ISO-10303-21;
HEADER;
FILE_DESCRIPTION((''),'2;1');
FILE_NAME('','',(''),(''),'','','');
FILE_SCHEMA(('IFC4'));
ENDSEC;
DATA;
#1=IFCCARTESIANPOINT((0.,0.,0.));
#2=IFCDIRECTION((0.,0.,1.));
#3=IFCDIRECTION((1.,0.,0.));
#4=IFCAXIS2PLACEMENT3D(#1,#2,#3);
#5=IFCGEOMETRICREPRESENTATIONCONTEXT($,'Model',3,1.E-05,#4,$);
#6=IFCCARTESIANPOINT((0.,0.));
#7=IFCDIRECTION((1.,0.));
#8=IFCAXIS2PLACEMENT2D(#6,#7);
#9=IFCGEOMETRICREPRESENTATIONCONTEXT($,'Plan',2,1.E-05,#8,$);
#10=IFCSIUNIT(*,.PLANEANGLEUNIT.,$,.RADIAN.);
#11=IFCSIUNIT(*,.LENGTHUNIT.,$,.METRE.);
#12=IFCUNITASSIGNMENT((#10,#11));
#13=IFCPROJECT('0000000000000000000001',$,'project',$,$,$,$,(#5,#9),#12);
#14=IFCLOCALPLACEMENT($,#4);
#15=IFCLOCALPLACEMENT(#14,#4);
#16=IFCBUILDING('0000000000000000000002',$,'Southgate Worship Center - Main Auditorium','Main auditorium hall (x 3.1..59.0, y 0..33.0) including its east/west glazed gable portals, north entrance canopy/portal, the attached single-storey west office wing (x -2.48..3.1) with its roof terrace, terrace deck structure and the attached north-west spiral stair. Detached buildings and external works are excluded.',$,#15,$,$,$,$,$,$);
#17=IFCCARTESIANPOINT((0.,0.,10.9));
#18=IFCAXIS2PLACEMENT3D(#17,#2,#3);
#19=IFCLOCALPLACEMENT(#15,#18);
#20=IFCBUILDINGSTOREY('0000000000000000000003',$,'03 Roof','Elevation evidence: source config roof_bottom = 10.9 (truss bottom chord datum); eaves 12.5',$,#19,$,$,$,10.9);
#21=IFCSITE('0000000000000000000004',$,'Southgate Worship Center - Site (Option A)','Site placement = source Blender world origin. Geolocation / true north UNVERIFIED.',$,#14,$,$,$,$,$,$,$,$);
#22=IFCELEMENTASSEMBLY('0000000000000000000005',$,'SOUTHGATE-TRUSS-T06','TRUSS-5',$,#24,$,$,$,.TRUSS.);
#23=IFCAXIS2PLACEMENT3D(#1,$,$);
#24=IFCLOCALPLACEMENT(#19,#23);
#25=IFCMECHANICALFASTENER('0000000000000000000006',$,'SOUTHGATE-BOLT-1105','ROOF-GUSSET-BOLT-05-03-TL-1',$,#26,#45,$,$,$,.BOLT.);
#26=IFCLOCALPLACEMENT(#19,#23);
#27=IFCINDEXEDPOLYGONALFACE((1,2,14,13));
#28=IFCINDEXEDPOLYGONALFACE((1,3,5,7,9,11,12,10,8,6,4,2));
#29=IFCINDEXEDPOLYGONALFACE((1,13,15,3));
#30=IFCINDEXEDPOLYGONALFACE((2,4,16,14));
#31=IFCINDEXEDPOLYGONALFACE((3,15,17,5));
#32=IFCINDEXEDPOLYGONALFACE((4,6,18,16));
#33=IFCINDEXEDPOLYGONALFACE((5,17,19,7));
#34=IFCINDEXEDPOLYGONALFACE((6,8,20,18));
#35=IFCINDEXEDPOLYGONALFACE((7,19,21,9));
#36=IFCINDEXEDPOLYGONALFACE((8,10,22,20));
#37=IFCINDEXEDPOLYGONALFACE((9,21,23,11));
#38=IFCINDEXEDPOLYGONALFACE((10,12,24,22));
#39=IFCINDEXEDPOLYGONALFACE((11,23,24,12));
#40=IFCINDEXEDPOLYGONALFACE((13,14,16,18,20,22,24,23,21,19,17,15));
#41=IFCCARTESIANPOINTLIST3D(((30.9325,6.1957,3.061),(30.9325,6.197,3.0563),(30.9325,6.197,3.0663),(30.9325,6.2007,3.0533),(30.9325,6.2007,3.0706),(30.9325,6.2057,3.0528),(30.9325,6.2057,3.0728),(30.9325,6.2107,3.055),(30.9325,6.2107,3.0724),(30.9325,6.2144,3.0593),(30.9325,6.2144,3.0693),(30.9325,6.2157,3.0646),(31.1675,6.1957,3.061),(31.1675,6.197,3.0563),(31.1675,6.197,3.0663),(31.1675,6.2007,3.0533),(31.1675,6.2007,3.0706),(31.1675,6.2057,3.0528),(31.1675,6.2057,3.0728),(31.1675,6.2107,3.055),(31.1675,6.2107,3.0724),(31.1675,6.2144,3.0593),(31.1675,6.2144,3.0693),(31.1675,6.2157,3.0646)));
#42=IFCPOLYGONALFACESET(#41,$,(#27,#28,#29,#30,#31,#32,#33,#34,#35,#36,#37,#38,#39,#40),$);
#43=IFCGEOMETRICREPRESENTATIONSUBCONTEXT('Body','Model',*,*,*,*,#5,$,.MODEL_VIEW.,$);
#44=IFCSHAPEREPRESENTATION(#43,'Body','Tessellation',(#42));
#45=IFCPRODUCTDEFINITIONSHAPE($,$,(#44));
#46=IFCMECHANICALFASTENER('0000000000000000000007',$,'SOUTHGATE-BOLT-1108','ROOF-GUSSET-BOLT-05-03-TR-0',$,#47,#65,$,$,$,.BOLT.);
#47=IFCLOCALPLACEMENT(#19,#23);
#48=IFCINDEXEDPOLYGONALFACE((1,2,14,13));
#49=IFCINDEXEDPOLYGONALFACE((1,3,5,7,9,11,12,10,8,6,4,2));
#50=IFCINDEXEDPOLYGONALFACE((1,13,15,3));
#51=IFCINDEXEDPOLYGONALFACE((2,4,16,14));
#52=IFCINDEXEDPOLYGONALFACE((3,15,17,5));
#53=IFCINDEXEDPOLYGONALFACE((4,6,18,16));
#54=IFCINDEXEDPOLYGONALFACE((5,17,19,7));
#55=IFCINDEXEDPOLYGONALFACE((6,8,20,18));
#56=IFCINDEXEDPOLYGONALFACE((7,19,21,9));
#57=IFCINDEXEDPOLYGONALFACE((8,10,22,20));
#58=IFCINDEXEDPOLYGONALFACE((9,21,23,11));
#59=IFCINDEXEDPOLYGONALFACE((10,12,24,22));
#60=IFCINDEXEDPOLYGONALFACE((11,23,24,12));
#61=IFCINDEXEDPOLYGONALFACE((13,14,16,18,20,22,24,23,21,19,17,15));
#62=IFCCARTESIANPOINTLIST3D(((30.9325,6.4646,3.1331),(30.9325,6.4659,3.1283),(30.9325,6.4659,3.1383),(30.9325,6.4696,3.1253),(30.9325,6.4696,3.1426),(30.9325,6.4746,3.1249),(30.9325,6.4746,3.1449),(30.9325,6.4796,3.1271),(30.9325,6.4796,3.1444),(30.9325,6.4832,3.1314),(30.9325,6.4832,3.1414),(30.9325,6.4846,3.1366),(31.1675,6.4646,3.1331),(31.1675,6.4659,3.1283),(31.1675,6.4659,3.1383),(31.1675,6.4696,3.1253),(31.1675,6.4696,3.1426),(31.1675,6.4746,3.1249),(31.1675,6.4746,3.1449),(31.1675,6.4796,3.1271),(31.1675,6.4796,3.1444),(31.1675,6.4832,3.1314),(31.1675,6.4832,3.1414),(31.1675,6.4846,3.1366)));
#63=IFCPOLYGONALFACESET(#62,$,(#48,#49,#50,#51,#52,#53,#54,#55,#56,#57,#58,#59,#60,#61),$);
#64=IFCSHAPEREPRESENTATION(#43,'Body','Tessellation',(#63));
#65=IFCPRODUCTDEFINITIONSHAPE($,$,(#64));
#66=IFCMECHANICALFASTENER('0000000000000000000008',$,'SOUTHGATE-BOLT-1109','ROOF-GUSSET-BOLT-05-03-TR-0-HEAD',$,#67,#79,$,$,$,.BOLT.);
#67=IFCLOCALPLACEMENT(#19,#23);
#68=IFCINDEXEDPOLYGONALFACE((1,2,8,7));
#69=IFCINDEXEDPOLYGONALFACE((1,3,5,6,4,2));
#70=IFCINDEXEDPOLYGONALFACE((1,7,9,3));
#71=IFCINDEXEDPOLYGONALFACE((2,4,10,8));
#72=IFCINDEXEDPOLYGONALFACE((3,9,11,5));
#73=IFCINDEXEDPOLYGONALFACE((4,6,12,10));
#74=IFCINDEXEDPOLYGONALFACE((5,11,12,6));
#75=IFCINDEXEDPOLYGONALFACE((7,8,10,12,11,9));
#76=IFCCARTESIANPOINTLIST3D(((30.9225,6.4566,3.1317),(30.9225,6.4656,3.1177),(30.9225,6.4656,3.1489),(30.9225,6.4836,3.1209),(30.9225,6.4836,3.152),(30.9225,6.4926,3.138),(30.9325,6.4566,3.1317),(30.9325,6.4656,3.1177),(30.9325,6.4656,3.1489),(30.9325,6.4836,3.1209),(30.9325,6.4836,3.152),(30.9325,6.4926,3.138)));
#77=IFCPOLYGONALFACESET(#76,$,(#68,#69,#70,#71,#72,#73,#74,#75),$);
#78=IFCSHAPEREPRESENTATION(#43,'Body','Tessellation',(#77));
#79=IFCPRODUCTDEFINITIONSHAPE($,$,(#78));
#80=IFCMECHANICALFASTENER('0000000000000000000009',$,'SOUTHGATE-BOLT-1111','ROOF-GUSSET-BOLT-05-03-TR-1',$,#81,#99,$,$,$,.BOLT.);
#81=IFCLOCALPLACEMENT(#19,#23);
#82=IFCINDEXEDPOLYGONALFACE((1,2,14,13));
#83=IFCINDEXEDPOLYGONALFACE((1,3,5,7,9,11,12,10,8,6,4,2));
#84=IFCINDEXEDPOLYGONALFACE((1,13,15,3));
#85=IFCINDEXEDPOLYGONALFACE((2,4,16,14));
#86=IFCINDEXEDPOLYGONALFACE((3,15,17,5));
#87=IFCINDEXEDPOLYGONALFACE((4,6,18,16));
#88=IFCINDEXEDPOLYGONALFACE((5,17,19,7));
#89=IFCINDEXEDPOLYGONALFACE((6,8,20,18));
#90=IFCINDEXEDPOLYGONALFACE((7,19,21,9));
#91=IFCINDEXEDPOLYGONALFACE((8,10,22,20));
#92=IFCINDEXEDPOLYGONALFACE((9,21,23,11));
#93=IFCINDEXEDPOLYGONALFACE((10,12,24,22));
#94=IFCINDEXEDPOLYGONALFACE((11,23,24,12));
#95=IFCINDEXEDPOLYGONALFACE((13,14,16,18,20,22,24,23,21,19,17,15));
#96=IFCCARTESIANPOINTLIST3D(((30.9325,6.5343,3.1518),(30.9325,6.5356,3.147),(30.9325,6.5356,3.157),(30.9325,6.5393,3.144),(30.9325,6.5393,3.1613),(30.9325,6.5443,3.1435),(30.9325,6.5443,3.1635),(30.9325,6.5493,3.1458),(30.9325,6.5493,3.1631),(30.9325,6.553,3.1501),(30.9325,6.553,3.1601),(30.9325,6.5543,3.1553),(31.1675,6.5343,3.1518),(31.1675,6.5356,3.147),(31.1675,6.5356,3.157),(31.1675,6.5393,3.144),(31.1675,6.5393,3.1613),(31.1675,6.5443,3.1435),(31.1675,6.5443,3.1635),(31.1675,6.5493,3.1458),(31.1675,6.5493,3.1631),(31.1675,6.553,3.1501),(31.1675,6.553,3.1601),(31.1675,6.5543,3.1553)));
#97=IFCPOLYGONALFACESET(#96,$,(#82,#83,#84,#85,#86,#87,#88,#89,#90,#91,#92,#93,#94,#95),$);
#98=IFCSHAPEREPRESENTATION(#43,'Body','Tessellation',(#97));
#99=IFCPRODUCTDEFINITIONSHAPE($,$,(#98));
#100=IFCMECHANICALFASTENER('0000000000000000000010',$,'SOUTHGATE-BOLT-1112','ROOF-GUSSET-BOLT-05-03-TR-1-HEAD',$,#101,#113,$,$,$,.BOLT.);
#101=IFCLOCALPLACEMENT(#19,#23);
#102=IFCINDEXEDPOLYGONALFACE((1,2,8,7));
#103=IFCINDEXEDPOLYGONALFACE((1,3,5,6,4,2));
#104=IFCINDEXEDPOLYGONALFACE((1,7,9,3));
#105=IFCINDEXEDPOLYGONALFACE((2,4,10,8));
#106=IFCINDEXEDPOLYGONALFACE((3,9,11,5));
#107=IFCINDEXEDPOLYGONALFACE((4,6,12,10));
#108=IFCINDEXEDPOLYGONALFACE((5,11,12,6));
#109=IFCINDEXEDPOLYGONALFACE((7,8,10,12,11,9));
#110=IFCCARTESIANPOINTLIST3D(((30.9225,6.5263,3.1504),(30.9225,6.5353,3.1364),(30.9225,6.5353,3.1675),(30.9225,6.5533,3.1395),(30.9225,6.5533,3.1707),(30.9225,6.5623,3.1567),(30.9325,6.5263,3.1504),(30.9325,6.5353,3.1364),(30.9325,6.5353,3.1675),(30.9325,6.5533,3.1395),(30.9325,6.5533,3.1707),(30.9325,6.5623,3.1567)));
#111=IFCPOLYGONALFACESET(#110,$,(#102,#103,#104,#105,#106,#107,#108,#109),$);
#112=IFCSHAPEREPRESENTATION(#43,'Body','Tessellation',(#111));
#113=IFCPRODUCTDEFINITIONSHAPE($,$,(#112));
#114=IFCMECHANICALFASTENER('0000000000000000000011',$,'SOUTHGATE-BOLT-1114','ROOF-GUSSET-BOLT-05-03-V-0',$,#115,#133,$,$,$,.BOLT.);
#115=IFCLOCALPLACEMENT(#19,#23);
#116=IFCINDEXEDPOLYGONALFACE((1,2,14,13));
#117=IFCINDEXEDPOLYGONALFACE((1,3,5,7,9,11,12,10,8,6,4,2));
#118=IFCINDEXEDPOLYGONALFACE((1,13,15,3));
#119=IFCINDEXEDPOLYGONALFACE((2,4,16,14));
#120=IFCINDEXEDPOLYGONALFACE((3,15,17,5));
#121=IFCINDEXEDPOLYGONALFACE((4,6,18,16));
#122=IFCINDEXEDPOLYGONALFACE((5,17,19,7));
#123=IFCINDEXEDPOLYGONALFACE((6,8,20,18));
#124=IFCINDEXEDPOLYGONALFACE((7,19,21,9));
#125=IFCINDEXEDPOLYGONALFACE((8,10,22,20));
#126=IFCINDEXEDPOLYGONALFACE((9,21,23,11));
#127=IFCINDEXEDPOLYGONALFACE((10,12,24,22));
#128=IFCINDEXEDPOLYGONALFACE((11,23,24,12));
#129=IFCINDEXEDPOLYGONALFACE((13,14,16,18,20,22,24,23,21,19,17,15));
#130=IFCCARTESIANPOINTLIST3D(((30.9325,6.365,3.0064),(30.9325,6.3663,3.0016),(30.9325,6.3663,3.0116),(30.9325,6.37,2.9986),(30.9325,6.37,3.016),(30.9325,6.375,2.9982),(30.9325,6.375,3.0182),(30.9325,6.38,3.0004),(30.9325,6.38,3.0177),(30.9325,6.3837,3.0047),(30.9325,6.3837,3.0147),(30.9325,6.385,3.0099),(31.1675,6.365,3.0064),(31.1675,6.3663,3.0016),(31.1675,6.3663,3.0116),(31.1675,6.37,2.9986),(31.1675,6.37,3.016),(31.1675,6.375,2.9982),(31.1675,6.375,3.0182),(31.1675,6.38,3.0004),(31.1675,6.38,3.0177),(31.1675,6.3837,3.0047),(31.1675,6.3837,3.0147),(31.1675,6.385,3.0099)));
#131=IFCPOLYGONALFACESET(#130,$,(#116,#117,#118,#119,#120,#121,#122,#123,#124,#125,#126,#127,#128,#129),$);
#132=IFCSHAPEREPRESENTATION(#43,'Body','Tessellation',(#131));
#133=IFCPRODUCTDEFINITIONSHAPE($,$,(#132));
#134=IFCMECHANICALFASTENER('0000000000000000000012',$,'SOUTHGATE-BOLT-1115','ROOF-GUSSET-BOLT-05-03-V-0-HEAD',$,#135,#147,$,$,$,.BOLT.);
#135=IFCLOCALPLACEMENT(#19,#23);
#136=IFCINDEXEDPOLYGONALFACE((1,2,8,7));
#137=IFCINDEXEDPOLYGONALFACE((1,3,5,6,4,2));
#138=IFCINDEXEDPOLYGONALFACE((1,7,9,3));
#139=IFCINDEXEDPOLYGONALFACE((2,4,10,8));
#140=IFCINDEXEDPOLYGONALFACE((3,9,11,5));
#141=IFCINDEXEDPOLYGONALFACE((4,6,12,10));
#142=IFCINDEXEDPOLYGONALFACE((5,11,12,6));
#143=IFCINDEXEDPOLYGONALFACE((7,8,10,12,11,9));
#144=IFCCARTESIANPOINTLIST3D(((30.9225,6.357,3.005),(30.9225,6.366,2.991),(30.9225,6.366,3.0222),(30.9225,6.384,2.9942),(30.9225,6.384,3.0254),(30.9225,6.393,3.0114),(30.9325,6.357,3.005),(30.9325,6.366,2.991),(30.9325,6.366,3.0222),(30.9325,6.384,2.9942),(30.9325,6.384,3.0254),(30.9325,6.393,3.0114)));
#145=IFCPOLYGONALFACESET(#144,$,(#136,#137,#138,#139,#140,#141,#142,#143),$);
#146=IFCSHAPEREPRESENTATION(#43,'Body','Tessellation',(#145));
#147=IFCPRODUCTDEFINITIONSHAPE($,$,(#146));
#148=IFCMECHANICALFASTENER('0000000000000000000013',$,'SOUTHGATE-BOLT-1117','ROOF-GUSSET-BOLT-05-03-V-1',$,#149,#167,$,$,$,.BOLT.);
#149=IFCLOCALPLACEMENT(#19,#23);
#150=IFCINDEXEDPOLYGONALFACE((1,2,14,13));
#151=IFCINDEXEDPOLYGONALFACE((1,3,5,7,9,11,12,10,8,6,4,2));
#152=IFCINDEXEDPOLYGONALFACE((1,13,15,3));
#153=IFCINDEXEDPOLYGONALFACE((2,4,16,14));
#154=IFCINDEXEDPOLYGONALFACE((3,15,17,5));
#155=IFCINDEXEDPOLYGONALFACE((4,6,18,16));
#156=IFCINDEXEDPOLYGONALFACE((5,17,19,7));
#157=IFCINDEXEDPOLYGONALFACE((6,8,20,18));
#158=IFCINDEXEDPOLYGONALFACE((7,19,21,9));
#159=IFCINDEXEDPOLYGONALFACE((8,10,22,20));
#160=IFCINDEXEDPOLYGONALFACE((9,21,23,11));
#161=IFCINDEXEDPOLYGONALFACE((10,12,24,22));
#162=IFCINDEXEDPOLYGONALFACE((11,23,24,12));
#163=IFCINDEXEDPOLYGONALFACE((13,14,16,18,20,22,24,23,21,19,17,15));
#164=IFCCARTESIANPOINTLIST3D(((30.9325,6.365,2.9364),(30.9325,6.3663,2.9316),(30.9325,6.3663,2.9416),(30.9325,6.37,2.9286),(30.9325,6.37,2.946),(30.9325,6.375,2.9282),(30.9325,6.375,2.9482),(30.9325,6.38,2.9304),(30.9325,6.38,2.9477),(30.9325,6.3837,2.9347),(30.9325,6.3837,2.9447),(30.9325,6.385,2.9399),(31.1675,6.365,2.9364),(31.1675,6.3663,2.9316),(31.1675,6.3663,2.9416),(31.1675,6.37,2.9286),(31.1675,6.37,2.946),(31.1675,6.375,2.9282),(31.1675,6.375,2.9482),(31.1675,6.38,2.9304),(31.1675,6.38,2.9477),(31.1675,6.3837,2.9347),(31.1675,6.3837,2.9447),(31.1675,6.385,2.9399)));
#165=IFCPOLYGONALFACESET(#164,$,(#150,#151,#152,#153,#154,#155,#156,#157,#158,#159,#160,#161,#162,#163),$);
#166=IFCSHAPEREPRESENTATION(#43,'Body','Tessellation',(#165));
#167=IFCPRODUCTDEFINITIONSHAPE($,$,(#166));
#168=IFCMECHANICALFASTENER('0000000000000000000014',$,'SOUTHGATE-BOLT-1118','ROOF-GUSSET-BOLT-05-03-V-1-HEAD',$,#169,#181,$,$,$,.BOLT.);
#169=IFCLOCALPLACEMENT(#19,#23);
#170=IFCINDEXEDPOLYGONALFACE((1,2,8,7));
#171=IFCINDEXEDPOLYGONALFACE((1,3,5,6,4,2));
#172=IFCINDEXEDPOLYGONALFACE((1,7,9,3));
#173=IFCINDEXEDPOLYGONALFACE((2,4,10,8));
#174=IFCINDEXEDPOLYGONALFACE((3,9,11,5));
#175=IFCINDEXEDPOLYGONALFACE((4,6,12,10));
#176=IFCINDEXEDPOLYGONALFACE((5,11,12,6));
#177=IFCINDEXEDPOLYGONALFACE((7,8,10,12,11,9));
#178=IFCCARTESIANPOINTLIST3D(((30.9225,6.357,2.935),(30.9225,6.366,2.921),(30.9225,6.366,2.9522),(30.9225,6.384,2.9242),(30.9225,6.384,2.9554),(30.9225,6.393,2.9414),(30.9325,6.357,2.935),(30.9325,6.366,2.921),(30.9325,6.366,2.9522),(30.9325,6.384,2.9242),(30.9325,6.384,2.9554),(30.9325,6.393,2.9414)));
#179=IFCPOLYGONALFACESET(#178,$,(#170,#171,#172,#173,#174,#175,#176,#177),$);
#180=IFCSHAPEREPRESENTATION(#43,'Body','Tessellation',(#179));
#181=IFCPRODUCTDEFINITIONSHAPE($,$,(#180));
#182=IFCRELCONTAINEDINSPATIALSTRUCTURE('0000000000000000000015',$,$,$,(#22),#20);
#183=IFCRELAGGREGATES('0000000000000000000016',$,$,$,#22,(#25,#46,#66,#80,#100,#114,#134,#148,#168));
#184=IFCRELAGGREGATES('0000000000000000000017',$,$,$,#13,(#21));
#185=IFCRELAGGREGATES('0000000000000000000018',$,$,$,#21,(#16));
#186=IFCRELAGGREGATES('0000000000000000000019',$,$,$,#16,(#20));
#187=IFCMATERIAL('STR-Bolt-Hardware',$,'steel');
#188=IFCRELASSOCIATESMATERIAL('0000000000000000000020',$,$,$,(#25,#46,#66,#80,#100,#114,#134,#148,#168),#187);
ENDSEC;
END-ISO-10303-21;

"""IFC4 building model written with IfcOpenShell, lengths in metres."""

from ifc_helpers import new_model, si_unit, frame, origin_with_axes, origin_2d_with_axis, place, context, subcontext, project, spatial, indexed_curve, outline, extrude, material, element, aggregate, save


model = new_model("IFC4")

# Units and contexts
model_context = context("Model", 3, precision=1e-05, world=origin_with_axes())
plan_context = context("Plan", 2, precision=1e-05, world=origin_2d_with_axis())
body_context = subcontext(model_context, "Body", "Model", "MODEL_VIEW")
ifc_project = project(units=[si_unit("PLANEANGLEUNIT", "RADIAN"), si_unit("LENGTHUNIT", "METRE")], contexts=[model_context, plan_context])

# Site, building, storey
site_placement = place(None, origin_with_axes())
site = spatial("IfcSite", under=ifc_project, at=site_placement, Name="Southgate Worship Center - Site (Option A)", Description="Site placement = source Blender world origin. Geolocation / true north UNVERIFIED.")
building_placement = place(site_placement, origin_with_axes())
building = spatial("IfcBuilding", under=site, at=building_placement, Name="Southgate Worship Center - Main Auditorium", Description="Main auditorium hall (x 3.1..59.0, y 0..33.0) including its east/west glazed gable portals, north entrance canopy/portal, the attached single-storey west office wing (x -2.48..3.1) with its roof terrace, terrace deck structure and the attached north-west spiral stair. Detached buildings and external works are excluded.")
storey_placement = place(building_placement, frame((0.0, 0.0, 10.9), z_axis=(0.0, 0.0, 1.0), x_axis=(1.0, 0.0, 0.0)))
storey = spatial("IfcBuildingStorey", under=building, at=storey_placement, Name="03 Roof", Description="Elevation evidence: source config roof_bottom = 10.9 (truss bottom chord datum); eaves 12.5", Elevation=10.9)

# Element assembly, mechanical fasteners
assembly_placement = place(storey_placement, origin_with_axes())
assembly = element("IfcElementAssembly", 1, at=assembly_placement, inside=storey, Name="SOUTHGATE-TRUSS-T06", Description="TRUSS-5", PredefinedType="TRUSS")
ifc_material = material(Name="STR-Bolt-Hardware", Category="steel")
mechanical_fastener_1_placement = place(assembly_placement, frame((30.9325, 6.1957, 3.0528), z_axis=(0.0, 0.0, 1.0), x_axis=(1.0, 0.0, 0.0)))
mechanical_fastener_1 = element("IfcMechanicalFastener", 2, at=mechanical_fastener_1_placement, material=ifc_material, Name="SOUTHGATE-BOLT-1105", Description="ROOF-GUSSET-BOLT-05-03-TL-1", PredefinedType="BOLT", context=body_context, shape_type="SweptSolid", body=[
    extrude(outline(indexed_curve([(0.0, 0.0), (0.0013, -0.0048), (0.005, -0.0078), (0.01, -0.0082), (0.015, -0.006), (0.0187, -0.0017), (0.02, 0.0035), (0.0187, 0.0083), (0.015, 0.0113), (0.01, 0.0118), (0.005, 0.0095), (0.0013, 0.0052), (0.0, 0.0)], self_intersect=False)), frame((0.0, 0.0, 0.0082), z_axis=(1.0, 0.0, 0.0), x_axis=(0.0, 1.0, 0.0)), (0.0, 0.0, 1.0), 0.235),
])
mechanical_fastener_2_placement = place(assembly_placement, frame((30.9325, 6.4646, 3.1249), z_axis=(0.0, 0.0, 1.0), x_axis=(1.0, 0.0, 0.0)))
mechanical_fastener_2 = element("IfcMechanicalFastener", 3, at=mechanical_fastener_2_placement, material=ifc_material, Name="SOUTHGATE-BOLT-1108", Description="ROOF-GUSSET-BOLT-05-03-TR-0", PredefinedType="BOLT", context=body_context, shape_type="SweptSolid", body=[
    extrude(outline(indexed_curve([(0.0, 0.0), (0.0013, -0.0048), (0.005, -0.0078), (0.01, -0.0082), (0.015, -0.006), (0.0187, -0.0017), (0.02, 0.0035), (0.0187, 0.0083), (0.015, 0.0113), (0.01, 0.0118), (0.005, 0.0095), (0.0013, 0.0052), (0.0, 0.0)], self_intersect=False)), frame((0.0, 0.0, 0.0082), z_axis=(1.0, 0.0, 0.0), x_axis=(0.0, 1.0, 0.0)), (0.0, 0.0, 1.0), 0.235),
])
mechanical_fastener_3_placement = place(assembly_placement, frame((30.9225, 6.4566, 3.1177), z_axis=(0.0, 0.0, 1.0), x_axis=(1.0, 0.0, 0.0)))
mechanical_fastener_3 = element("IfcMechanicalFastener", 4, at=mechanical_fastener_3_placement, material=ifc_material, Name="SOUTHGATE-BOLT-1109", Description="ROOF-GUSSET-BOLT-05-03-TR-0-HEAD", PredefinedType="BOLT", context=body_context, shape_type="SweptSolid", body=[
    extrude(outline(indexed_curve([(0.0, 0.0), (0.009, -0.014), (0.027, -0.0108), (0.036, 0.0064), (0.027, 0.0204), (0.009, 0.0172), (0.0, 0.0)], self_intersect=False)), frame((0.0, 0.0, 0.014), z_axis=(1.0, 0.0, 0.0), x_axis=(0.0, 1.0, 0.0)), (0.0, 0.0, 1.0), 0.01),
])
mechanical_fastener_4_placement = place(assembly_placement, frame((30.9325, 6.5343, 3.1435), z_axis=(0.0, 0.0, 1.0), x_axis=(1.0, 0.0, 0.0)))
mechanical_fastener_4 = element("IfcMechanicalFastener", 5, at=mechanical_fastener_4_placement, material=ifc_material, Name="SOUTHGATE-BOLT-1111", Description="ROOF-GUSSET-BOLT-05-03-TR-1", PredefinedType="BOLT", context=body_context, shape_type="SweptSolid", body=[
    extrude(outline(indexed_curve([(0.0, 0.0), (0.0013, -0.0048), (0.005, -0.0078), (0.01, -0.0082), (0.015, -0.006), (0.0187, -0.0017), (0.02, 0.0035), (0.0187, 0.0083), (0.015, 0.0113), (0.01, 0.0118), (0.005, 0.0095), (0.0013, 0.0052), (0.0, 0.0)], self_intersect=False)), frame((0.0, 0.0, 0.0083), z_axis=(1.0, 0.0, 0.0), x_axis=(0.0, 1.0, 0.0)), (0.0, 0.0, 1.0), 0.235),
])
mechanical_fastener_5_placement = place(assembly_placement, frame((30.9225, 6.5263, 3.1364), z_axis=(0.0, 0.0, 1.0), x_axis=(1.0, 0.0, 0.0)))
mechanical_fastener_5 = element("IfcMechanicalFastener", 6, at=mechanical_fastener_5_placement, material=ifc_material, Name="SOUTHGATE-BOLT-1112", Description="ROOF-GUSSET-BOLT-05-03-TR-1-HEAD", PredefinedType="BOLT", context=body_context, shape_type="SweptSolid", body=[
    extrude(outline(indexed_curve([(0.0, 0.0), (0.009, -0.014), (0.027, -0.0108), (0.036, 0.0064), (0.027, 0.0204), (0.009, 0.0172), (0.0, 0.0)], self_intersect=False)), frame((0.0, 0.0, 0.014), z_axis=(1.0, 0.0, 0.0), x_axis=(0.0, 1.0, 0.0)), (0.0, 0.0, 1.0), 0.01),
])
mechanical_fastener_6_placement = place(assembly_placement, frame((30.9325, 6.365, 2.9982), z_axis=(0.0, 0.0, 1.0), x_axis=(1.0, 0.0, 0.0)))
mechanical_fastener_6 = element("IfcMechanicalFastener", 7, at=mechanical_fastener_6_placement, material=ifc_material, Name="SOUTHGATE-BOLT-1114", Description="ROOF-GUSSET-BOLT-05-03-V-0", PredefinedType="BOLT", context=body_context, shape_type="SweptSolid", body=[
    extrude(outline(indexed_curve([(0.0, 0.0), (0.0013, -0.0048), (0.005, -0.0078), (0.01, -0.0082), (0.015, -0.006), (0.0187, -0.0017), (0.02, 0.0035), (0.0187, 0.0083), (0.015, 0.0113), (0.01, 0.0118), (0.005, 0.0095), (0.0013, 0.0052), (0.0, 0.0)], self_intersect=False)), frame((0.0, 0.0, 0.0082), z_axis=(1.0, 0.0, 0.0), x_axis=(0.0, 1.0, 0.0)), (0.0, 0.0, 1.0), 0.235),
])
mechanical_fastener_7_placement = place(assembly_placement, frame((30.9225, 6.357, 2.991), z_axis=(0.0, 0.0, 1.0), x_axis=(1.0, 0.0, 0.0)))
mechanical_fastener_7 = element("IfcMechanicalFastener", 8, at=mechanical_fastener_7_placement, material=ifc_material, Name="SOUTHGATE-BOLT-1115", Description="ROOF-GUSSET-BOLT-05-03-V-0-HEAD", PredefinedType="BOLT", context=body_context, shape_type="SweptSolid", body=[
    extrude(outline(indexed_curve([(0.0, 0.0), (0.009, -0.014), (0.027, -0.0108), (0.036, 0.0064), (0.027, 0.0204), (0.009, 0.0172), (0.0, 0.0)], self_intersect=False)), frame((0.0, 0.0, 0.014), z_axis=(1.0, 0.0, 0.0), x_axis=(0.0, 1.0, 0.0)), (0.0, 0.0, 1.0), 0.01),
])
mechanical_fastener_8_placement = place(assembly_placement, frame((30.9325, 6.365, 2.9282), z_axis=(0.0, 0.0, 1.0), x_axis=(1.0, 0.0, 0.0)))
mechanical_fastener_8 = element("IfcMechanicalFastener", 9, at=mechanical_fastener_8_placement, material=ifc_material, Name="SOUTHGATE-BOLT-1117", Description="ROOF-GUSSET-BOLT-05-03-V-1", PredefinedType="BOLT", context=body_context, shape_type="SweptSolid", body=[
    extrude(outline(indexed_curve([(0.0, 0.0), (0.0013, -0.0048), (0.005, -0.0078), (0.01, -0.0082), (0.015, -0.006), (0.0187, -0.0017), (0.02, 0.0035), (0.0187, 0.0083), (0.015, 0.0113), (0.01, 0.0118), (0.005, 0.0095), (0.0013, 0.0052), (0.0, 0.0)], self_intersect=False)), frame((0.0, 0.0, 0.0082), z_axis=(1.0, 0.0, 0.0), x_axis=(0.0, 1.0, 0.0)), (0.0, 0.0, 1.0), 0.235),
])
mechanical_fastener_9_placement = place(assembly_placement, frame((30.9225, 6.357, 2.921), z_axis=(0.0, 0.0, 1.0), x_axis=(1.0, 0.0, 0.0)))
mechanical_fastener_9 = element("IfcMechanicalFastener", 10, at=mechanical_fastener_9_placement, material=ifc_material, Name="SOUTHGATE-BOLT-1118", Description="ROOF-GUSSET-BOLT-05-03-V-1-HEAD", PredefinedType="BOLT", context=body_context, shape_type="SweptSolid", body=[
    extrude(outline(indexed_curve([(0.0, 0.0), (0.009, -0.014), (0.027, -0.0108), (0.036, 0.0064), (0.027, 0.0204), (0.009, 0.0172), (0.0, 0.0)], self_intersect=False)), frame((0.0, 0.0, 0.014), z_axis=(1.0, 0.0, 0.0), x_axis=(0.0, 1.0, 0.0)), (0.0, 0.0, 1.0), 0.01),
])
aggregate(assembly, [mechanical_fastener_1, mechanical_fastener_2, mechanical_fastener_3, mechanical_fastener_4, mechanical_fastener_5, mechanical_fastener_6, mechanical_fastener_7, mechanical_fastener_8, mechanical_fastener_9])

save(model, "model.ifc")
